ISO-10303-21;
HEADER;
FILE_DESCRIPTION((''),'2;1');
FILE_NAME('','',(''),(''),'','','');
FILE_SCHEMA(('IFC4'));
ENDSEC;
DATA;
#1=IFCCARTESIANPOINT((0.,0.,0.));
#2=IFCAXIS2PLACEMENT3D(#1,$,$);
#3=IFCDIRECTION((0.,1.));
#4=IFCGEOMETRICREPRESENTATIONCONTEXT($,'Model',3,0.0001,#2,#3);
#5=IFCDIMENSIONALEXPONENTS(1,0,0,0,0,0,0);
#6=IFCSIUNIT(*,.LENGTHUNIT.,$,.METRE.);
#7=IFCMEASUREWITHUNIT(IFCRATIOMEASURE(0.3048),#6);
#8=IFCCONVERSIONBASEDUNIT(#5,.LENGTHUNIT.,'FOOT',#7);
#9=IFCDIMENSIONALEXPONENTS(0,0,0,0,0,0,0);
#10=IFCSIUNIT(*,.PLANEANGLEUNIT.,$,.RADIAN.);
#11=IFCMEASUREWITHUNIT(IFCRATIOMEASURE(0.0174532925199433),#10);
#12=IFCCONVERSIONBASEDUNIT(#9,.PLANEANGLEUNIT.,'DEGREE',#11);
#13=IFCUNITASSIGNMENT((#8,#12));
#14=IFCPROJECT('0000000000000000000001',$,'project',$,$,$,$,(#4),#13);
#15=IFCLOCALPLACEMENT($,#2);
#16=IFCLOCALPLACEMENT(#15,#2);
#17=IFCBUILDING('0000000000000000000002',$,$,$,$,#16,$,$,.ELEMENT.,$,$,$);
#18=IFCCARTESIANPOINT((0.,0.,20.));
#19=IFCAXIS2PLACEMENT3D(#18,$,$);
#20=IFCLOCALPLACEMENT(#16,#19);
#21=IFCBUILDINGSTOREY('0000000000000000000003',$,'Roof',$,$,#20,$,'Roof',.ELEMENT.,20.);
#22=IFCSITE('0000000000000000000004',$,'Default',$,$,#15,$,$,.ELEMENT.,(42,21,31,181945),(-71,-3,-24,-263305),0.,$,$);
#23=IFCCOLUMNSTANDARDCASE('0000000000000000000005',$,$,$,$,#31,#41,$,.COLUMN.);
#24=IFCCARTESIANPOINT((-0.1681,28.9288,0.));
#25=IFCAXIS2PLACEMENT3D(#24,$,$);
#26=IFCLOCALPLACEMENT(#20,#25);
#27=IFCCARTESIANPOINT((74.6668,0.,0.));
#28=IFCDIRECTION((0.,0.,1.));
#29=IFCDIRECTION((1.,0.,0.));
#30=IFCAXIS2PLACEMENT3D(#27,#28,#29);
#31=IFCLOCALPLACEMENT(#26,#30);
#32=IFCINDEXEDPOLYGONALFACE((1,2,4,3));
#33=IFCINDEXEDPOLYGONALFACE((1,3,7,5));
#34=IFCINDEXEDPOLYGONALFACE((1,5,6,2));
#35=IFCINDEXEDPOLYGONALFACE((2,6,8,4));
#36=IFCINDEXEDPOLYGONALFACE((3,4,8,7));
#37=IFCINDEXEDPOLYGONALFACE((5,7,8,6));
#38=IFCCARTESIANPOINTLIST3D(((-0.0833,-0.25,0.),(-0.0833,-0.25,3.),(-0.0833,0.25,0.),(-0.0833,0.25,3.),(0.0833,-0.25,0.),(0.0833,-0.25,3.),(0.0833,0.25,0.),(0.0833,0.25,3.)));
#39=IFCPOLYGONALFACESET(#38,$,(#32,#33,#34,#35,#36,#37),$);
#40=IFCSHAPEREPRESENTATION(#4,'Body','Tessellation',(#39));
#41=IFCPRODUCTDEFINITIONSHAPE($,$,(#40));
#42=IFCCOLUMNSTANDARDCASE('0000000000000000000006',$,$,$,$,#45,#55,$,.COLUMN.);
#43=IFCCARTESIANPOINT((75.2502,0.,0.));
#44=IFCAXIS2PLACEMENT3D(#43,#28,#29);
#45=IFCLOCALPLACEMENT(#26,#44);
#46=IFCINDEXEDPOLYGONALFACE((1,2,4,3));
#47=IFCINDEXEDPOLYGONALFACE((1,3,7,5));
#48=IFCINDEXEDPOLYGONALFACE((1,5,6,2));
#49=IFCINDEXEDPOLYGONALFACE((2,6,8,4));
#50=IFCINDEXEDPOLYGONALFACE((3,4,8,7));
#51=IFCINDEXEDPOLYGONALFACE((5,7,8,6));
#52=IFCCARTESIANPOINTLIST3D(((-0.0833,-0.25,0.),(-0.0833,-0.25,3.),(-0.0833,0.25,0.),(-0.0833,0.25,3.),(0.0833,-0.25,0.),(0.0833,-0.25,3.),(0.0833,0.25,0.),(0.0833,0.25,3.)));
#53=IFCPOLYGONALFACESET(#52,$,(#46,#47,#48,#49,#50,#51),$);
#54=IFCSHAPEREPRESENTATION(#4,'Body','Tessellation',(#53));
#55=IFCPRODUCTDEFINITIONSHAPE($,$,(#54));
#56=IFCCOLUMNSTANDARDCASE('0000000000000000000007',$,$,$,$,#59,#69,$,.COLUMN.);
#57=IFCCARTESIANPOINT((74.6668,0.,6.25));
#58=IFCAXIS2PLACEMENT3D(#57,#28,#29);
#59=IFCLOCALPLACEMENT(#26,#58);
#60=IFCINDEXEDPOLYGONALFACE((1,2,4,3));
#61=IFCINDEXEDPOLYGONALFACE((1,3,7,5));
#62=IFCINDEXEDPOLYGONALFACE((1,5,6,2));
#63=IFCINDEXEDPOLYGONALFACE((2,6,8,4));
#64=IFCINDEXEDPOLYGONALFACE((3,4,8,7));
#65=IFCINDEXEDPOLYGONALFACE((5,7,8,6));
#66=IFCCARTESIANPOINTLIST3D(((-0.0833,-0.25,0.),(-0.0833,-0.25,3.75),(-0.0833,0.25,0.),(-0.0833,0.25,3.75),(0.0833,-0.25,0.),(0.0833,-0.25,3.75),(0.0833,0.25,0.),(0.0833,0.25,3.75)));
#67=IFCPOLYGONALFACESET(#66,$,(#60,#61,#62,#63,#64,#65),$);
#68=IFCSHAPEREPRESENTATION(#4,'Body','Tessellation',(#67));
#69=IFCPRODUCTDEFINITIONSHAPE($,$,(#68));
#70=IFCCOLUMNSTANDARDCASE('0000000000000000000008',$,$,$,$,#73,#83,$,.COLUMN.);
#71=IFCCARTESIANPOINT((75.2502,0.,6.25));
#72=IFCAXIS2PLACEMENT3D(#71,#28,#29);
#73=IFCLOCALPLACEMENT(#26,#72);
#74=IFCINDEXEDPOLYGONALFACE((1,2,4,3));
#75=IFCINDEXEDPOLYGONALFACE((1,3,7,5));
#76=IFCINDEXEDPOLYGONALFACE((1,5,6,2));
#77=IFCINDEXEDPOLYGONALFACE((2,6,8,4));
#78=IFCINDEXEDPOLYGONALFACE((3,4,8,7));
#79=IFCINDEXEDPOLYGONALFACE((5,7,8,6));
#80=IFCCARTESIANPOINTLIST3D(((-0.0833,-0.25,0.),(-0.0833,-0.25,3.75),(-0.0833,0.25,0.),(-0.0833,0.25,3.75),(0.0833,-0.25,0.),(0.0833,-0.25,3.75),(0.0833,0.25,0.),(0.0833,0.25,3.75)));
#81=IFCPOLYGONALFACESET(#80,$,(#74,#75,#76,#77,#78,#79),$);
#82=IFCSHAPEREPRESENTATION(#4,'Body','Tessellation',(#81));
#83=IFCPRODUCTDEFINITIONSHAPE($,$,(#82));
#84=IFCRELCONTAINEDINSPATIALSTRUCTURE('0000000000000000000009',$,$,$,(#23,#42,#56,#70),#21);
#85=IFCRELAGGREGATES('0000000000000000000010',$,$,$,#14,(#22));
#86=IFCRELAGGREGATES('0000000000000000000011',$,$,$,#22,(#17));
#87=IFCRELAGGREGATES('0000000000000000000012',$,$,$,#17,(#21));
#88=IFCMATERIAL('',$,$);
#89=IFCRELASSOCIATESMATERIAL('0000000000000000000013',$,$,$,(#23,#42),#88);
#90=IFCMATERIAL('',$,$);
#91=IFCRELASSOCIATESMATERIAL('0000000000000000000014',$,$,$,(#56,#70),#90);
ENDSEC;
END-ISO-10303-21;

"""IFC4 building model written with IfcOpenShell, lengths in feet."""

from ifc_helpers import new_model, entity, si_unit, converted_unit, direction, frame, origin, place, context, project, spatial, rectangle, extrude, material, element, save


model = new_model("IFC4")

# Units and contexts
model_context = context("Model", 3, precision=0.0001, world=origin(), true_north=direction((0.0, 1.0)))
ifc_project = project(units=[converted_unit("LENGTHUNIT", "FOOT", entity("IfcRatioMeasure", 0.3048), si_unit("LENGTHUNIT", "METRE"), dimensions=[1, 0, 0, 0, 0, 0, 0]), converted_unit("PLANEANGLEUNIT", "DEGREE", entity("IfcRatioMeasure", 0.0174532925199433), si_unit("PLANEANGLEUNIT", "RADIAN"), dimensions=[0, 0, 0, 0, 0, 0, 0])], contexts=[model_context])

# Site, building, storey
site_placement = place(None, origin())
site = spatial("IfcSite", under=ifc_project, at=site_placement, Name="Default", CompositionType="ELEMENT", RefLatitude=(42, 21, 31, 181945), RefLongitude=(-71, -3, -24, -263305), RefElevation=0.0)
building_placement = place(site_placement, origin())
building = spatial("IfcBuilding", under=site, at=building_placement, CompositionType="ELEMENT")
storey_placement = place(building_placement, frame((0.0, 0.0, 20.0)))
storey = spatial("IfcBuildingStorey", under=building, at=storey_placement, Name="Roof", LongName="Roof", CompositionType="ELEMENT", Elevation=20.0)

# Columns
ifc_material_1 = material(Name="")
placement = place(storey_placement, frame((-0.1681, 28.9288, 0.0)))
for number, where, z_axis, x_axis in (
    (1, (74.6668, 0.0, 0.0), (0.0, 0.0, 1.0), (1.0, 0.0, 0.0)),
    (2, (75.2502, 0.0, 0.0), (0.0, 0.0, 1.0), (1.0, 0.0, 0.0)),
):
    element("IfcColumnStandardCase", number, at=place(placement, frame(where, z_axis=z_axis, x_axis=x_axis)), inside=storey, material=ifc_material_1, PredefinedType="COLUMN", context=model_context, shape_type="SweptSolid", body=[
        extrude(rectangle(XDim=0.1667, YDim=0.5), origin(), (0.0, 0.0, 1.0), 3.0),
    ])
ifc_material_2 = material(Name="")
for number, where, z_axis, x_axis in (
    (3, (74.6668, 0.0, 6.25), (0.0, 0.0, 1.0), (1.0, 0.0, 0.0)),
    (4, (75.2502, 0.0, 6.25), (0.0, 0.0, 1.0), (1.0, 0.0, 0.0)),
):
    element("IfcColumnStandardCase", number, at=place(placement, frame(where, z_axis=z_axis, x_axis=x_axis)), inside=storey, material=ifc_material_2, PredefinedType="COLUMN", context=model_context, shape_type="SweptSolid", body=[
        extrude(rectangle(XDim=0.1667, YDim=0.5), origin(), (0.0, 0.0, 1.0), 3.75),
    ])

save(model, "model.ifc")
